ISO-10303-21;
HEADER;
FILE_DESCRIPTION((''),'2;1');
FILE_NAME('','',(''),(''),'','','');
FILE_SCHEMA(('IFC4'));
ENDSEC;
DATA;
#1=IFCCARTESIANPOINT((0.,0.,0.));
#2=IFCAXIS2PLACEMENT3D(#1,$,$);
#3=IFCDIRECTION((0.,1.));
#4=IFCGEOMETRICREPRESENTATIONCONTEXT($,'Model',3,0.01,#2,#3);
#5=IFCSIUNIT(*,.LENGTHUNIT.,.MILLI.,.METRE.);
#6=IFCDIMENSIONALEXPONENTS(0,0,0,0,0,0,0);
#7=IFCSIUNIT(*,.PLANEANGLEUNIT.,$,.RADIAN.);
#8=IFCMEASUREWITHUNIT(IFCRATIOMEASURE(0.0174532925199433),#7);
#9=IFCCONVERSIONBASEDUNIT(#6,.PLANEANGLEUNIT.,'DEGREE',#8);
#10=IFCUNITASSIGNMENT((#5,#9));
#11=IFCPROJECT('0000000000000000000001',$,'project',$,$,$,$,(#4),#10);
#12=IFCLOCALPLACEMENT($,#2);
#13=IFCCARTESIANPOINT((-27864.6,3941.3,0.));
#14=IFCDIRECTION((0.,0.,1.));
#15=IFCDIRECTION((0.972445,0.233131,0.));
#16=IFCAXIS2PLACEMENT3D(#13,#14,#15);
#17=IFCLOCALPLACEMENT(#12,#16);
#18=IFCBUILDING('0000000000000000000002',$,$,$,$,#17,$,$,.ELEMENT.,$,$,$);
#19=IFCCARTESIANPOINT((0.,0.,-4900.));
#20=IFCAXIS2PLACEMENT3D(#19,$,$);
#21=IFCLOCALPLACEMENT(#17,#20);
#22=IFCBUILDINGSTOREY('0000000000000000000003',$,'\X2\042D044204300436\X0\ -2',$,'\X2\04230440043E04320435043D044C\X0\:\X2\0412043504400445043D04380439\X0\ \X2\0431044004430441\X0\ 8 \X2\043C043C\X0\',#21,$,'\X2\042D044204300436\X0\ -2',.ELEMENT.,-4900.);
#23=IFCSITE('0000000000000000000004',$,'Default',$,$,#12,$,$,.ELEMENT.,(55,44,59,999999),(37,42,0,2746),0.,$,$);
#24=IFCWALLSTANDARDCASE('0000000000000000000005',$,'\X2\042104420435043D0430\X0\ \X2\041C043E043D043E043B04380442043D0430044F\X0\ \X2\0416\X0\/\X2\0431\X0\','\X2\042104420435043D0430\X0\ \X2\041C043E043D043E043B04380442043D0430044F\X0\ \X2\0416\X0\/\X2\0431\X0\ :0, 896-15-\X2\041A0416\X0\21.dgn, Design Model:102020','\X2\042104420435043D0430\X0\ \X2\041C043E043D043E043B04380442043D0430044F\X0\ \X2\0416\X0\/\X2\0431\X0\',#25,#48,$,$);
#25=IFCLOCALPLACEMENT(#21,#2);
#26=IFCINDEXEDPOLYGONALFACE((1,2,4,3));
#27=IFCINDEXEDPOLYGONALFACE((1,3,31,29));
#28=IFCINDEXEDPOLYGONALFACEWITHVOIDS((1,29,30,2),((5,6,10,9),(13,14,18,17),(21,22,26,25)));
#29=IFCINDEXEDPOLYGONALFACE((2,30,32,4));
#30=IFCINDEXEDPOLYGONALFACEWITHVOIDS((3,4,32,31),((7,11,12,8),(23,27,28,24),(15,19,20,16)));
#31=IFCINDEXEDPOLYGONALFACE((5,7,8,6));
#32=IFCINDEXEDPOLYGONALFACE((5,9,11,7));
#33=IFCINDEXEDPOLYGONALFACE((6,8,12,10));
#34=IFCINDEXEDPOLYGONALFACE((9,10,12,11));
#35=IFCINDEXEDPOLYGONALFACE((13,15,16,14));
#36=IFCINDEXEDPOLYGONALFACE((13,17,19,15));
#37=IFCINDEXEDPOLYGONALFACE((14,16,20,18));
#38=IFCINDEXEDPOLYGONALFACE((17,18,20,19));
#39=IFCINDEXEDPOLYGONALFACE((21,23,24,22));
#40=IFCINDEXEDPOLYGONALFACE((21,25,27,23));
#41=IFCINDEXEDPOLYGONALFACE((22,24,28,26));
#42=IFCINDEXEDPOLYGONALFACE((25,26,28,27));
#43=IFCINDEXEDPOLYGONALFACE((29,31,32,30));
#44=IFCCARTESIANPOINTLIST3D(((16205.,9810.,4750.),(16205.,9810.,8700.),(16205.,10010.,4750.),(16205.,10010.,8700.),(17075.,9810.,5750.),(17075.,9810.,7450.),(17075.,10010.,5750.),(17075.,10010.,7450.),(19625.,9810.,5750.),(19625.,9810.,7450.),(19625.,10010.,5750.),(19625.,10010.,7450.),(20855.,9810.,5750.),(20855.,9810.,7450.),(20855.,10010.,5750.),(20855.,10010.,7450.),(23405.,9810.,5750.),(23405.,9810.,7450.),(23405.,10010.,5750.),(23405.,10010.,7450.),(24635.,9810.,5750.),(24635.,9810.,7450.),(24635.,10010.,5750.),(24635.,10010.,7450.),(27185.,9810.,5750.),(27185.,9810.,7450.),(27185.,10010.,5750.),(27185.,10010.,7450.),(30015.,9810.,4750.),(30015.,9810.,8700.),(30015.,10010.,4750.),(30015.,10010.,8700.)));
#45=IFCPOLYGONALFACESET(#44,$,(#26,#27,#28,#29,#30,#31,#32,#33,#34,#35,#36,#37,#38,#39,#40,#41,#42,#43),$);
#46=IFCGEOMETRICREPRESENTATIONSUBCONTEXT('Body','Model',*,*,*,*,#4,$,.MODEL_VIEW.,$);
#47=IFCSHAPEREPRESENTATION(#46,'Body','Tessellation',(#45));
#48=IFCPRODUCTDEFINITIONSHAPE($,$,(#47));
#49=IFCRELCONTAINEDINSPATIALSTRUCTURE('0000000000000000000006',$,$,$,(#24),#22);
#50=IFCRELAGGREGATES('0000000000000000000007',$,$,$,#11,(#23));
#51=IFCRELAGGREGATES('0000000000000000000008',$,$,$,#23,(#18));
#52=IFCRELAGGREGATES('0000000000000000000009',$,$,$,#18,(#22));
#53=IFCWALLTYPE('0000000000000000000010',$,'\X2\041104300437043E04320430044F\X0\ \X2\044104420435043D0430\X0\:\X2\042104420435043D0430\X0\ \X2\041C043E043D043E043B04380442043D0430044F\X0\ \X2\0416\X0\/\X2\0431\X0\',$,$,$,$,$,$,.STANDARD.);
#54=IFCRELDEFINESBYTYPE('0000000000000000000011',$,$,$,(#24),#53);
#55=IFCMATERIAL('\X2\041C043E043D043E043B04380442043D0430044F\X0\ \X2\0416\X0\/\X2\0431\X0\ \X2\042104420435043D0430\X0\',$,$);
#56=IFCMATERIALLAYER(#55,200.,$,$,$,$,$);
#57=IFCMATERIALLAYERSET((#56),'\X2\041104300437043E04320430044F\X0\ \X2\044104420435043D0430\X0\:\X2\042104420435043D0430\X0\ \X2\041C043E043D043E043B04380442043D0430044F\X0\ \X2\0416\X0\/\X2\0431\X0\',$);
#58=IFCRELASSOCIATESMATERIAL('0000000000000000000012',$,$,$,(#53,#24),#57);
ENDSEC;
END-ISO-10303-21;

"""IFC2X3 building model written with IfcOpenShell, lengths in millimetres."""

from ifc_helpers import new_model, entity, si_unit, converted_unit, direction, frame, frame_2d, origin, origin_2d_with_axis, place, context, subcontext, project, spatial, rectangle, extrude, material, layer, layer_set, layer_usage, type_object, element, save


model = new_model("IFC2X3")

# Units and contexts
model_context = context("Model", 3, precision=0.01, world=origin(), true_north=direction((0.0, 1.0)))
body_context = subcontext(model_context, "Body", "Model", "MODEL_VIEW")
ifc_project = project(units=[si_unit("LENGTHUNIT", "METRE", prefix="MILLI"), converted_unit("PLANEANGLEUNIT", "DEGREE", entity("IfcRatioMeasure", 0.0174532925199433), si_unit("PLANEANGLEUNIT", "RADIAN"), dimensions=[0, 0, 0, 0, 0, 0, 0])], contexts=[model_context])

# Site, building, storey
site_placement = place(None, origin())
site = spatial("IfcSite", under=ifc_project, at=site_placement, Name="Default", CompositionType="ELEMENT", RefLatitude=(55, 44, 59, 999999), RefLongitude=(37, 42, 0, 2746), RefElevation=0.0)
building_placement = place(site_placement, frame((-27864.6, 3941.3, 0.0), z_axis=(0.0, 0.0, 1.0), x_axis=(0.972445, 0.233131, 0.0)))
building = spatial("IfcBuilding", under=site, at=building_placement, CompositionType="ELEMENT")
storey_placement = place(building_placement, frame((0.0, 0.0, -4900.0)))
storey = spatial("IfcBuildingStorey", under=building, at=storey_placement, Name="Этаж -2", ObjectType="Уровень:Верхний брус 8 мм", LongName="Этаж -2", CompositionType="ELEMENT", Elevation=-4900.0)

# Wall, openings
ifc_material = material(Name="Монолитная Ж/б Стена")
ifc_layer_1 = layer(ifc_material, 200.0)
ifc_layer_set_1 = layer_set([ifc_layer_1], Name="Базовая стена:Стена Монолитная Ж/б")
ifc_layer_usage_1 = layer_usage(ifc_layer_set_1, "AXIS2", "NEGATIVE", 100.0)
wall_type_1 = type_object("IfcWallType", Name="Базовая стена:Стена Монолитная Ж/б", PredefinedType="STANDARD", material=ifc_layer_set_1)
wall_1_placement = place(storey_placement, frame((16205.0, 9910.0, 4750.0)))
wall_1 = element("IfcWallStandardCase", 1, at=wall_1_placement, inside=storey, type_object=wall_type_1, material=ifc_layer_usage_1, Name="Стена Монолитная Ж/б", Description="Стена Монолитная Ж/б :0, 896-15-КЖ21.dgn, Design Model:102020", ObjectType="Стена Монолитная Ж/б", context=body_context, shape_type="SweptSolid", body=[
    extrude(rectangle(XDim=13810.0, YDim=200.0, at=frame_2d((6905.0, 0.0), x_axis=(-1.0, 0.0))), origin(), (0.0, 0.0, 1.0), 3950.0),
])
opening_1_placement = place(wall_1_placement, origin())
element("IfcOpeningElement", 2, at=opening_1_placement, cuts=wall_1, ObjectType="Opening", context=body_context, shape_type="SweptSolid", body=[
    extrude(rectangle(XDim=1700.0, YDim=2550.0, at=origin_2d_with_axis()), frame((2145.0, -100.0, 1850.0), z_axis=(0.0, 1.0, 0.0), x_axis=(0.0, 0.0, -1.0)), (0.0, 0.0, 1.0), 200.0),
])
opening_2_placement = place(wall_1_placement, origin())
element("IfcOpeningElement", 3, at=opening_2_placement, cuts=wall_1, ObjectType="Opening", context=body_context, shape_type="SweptSolid", body=[
    extrude(rectangle(XDim=1700.0, YDim=2550.0, at=origin_2d_with_axis()), frame((5925.0, -100.0, 1850.0), z_axis=(0.0, 1.0, 0.0), x_axis=(0.0, 0.0, -1.0)), (0.0, 0.0, 1.0), 200.0),
])
opening_3_placement = place(wall_1_placement, origin())
element("IfcOpeningElement", 4, at=opening_3_placement, cuts=wall_1, ObjectType="Opening", context=body_context, shape_type="SweptSolid", body=[
    extrude(rectangle(XDim=1700.0, YDim=2550.0, at=origin_2d_with_axis()), frame((9705.0, -100.0, 1850.0), z_axis=(0.0, 1.0, 0.0), x_axis=(0.0, 0.0, -1.0)), (0.0, 0.0, 1.0), 200.0),
])

save(model, "model.ifc")
